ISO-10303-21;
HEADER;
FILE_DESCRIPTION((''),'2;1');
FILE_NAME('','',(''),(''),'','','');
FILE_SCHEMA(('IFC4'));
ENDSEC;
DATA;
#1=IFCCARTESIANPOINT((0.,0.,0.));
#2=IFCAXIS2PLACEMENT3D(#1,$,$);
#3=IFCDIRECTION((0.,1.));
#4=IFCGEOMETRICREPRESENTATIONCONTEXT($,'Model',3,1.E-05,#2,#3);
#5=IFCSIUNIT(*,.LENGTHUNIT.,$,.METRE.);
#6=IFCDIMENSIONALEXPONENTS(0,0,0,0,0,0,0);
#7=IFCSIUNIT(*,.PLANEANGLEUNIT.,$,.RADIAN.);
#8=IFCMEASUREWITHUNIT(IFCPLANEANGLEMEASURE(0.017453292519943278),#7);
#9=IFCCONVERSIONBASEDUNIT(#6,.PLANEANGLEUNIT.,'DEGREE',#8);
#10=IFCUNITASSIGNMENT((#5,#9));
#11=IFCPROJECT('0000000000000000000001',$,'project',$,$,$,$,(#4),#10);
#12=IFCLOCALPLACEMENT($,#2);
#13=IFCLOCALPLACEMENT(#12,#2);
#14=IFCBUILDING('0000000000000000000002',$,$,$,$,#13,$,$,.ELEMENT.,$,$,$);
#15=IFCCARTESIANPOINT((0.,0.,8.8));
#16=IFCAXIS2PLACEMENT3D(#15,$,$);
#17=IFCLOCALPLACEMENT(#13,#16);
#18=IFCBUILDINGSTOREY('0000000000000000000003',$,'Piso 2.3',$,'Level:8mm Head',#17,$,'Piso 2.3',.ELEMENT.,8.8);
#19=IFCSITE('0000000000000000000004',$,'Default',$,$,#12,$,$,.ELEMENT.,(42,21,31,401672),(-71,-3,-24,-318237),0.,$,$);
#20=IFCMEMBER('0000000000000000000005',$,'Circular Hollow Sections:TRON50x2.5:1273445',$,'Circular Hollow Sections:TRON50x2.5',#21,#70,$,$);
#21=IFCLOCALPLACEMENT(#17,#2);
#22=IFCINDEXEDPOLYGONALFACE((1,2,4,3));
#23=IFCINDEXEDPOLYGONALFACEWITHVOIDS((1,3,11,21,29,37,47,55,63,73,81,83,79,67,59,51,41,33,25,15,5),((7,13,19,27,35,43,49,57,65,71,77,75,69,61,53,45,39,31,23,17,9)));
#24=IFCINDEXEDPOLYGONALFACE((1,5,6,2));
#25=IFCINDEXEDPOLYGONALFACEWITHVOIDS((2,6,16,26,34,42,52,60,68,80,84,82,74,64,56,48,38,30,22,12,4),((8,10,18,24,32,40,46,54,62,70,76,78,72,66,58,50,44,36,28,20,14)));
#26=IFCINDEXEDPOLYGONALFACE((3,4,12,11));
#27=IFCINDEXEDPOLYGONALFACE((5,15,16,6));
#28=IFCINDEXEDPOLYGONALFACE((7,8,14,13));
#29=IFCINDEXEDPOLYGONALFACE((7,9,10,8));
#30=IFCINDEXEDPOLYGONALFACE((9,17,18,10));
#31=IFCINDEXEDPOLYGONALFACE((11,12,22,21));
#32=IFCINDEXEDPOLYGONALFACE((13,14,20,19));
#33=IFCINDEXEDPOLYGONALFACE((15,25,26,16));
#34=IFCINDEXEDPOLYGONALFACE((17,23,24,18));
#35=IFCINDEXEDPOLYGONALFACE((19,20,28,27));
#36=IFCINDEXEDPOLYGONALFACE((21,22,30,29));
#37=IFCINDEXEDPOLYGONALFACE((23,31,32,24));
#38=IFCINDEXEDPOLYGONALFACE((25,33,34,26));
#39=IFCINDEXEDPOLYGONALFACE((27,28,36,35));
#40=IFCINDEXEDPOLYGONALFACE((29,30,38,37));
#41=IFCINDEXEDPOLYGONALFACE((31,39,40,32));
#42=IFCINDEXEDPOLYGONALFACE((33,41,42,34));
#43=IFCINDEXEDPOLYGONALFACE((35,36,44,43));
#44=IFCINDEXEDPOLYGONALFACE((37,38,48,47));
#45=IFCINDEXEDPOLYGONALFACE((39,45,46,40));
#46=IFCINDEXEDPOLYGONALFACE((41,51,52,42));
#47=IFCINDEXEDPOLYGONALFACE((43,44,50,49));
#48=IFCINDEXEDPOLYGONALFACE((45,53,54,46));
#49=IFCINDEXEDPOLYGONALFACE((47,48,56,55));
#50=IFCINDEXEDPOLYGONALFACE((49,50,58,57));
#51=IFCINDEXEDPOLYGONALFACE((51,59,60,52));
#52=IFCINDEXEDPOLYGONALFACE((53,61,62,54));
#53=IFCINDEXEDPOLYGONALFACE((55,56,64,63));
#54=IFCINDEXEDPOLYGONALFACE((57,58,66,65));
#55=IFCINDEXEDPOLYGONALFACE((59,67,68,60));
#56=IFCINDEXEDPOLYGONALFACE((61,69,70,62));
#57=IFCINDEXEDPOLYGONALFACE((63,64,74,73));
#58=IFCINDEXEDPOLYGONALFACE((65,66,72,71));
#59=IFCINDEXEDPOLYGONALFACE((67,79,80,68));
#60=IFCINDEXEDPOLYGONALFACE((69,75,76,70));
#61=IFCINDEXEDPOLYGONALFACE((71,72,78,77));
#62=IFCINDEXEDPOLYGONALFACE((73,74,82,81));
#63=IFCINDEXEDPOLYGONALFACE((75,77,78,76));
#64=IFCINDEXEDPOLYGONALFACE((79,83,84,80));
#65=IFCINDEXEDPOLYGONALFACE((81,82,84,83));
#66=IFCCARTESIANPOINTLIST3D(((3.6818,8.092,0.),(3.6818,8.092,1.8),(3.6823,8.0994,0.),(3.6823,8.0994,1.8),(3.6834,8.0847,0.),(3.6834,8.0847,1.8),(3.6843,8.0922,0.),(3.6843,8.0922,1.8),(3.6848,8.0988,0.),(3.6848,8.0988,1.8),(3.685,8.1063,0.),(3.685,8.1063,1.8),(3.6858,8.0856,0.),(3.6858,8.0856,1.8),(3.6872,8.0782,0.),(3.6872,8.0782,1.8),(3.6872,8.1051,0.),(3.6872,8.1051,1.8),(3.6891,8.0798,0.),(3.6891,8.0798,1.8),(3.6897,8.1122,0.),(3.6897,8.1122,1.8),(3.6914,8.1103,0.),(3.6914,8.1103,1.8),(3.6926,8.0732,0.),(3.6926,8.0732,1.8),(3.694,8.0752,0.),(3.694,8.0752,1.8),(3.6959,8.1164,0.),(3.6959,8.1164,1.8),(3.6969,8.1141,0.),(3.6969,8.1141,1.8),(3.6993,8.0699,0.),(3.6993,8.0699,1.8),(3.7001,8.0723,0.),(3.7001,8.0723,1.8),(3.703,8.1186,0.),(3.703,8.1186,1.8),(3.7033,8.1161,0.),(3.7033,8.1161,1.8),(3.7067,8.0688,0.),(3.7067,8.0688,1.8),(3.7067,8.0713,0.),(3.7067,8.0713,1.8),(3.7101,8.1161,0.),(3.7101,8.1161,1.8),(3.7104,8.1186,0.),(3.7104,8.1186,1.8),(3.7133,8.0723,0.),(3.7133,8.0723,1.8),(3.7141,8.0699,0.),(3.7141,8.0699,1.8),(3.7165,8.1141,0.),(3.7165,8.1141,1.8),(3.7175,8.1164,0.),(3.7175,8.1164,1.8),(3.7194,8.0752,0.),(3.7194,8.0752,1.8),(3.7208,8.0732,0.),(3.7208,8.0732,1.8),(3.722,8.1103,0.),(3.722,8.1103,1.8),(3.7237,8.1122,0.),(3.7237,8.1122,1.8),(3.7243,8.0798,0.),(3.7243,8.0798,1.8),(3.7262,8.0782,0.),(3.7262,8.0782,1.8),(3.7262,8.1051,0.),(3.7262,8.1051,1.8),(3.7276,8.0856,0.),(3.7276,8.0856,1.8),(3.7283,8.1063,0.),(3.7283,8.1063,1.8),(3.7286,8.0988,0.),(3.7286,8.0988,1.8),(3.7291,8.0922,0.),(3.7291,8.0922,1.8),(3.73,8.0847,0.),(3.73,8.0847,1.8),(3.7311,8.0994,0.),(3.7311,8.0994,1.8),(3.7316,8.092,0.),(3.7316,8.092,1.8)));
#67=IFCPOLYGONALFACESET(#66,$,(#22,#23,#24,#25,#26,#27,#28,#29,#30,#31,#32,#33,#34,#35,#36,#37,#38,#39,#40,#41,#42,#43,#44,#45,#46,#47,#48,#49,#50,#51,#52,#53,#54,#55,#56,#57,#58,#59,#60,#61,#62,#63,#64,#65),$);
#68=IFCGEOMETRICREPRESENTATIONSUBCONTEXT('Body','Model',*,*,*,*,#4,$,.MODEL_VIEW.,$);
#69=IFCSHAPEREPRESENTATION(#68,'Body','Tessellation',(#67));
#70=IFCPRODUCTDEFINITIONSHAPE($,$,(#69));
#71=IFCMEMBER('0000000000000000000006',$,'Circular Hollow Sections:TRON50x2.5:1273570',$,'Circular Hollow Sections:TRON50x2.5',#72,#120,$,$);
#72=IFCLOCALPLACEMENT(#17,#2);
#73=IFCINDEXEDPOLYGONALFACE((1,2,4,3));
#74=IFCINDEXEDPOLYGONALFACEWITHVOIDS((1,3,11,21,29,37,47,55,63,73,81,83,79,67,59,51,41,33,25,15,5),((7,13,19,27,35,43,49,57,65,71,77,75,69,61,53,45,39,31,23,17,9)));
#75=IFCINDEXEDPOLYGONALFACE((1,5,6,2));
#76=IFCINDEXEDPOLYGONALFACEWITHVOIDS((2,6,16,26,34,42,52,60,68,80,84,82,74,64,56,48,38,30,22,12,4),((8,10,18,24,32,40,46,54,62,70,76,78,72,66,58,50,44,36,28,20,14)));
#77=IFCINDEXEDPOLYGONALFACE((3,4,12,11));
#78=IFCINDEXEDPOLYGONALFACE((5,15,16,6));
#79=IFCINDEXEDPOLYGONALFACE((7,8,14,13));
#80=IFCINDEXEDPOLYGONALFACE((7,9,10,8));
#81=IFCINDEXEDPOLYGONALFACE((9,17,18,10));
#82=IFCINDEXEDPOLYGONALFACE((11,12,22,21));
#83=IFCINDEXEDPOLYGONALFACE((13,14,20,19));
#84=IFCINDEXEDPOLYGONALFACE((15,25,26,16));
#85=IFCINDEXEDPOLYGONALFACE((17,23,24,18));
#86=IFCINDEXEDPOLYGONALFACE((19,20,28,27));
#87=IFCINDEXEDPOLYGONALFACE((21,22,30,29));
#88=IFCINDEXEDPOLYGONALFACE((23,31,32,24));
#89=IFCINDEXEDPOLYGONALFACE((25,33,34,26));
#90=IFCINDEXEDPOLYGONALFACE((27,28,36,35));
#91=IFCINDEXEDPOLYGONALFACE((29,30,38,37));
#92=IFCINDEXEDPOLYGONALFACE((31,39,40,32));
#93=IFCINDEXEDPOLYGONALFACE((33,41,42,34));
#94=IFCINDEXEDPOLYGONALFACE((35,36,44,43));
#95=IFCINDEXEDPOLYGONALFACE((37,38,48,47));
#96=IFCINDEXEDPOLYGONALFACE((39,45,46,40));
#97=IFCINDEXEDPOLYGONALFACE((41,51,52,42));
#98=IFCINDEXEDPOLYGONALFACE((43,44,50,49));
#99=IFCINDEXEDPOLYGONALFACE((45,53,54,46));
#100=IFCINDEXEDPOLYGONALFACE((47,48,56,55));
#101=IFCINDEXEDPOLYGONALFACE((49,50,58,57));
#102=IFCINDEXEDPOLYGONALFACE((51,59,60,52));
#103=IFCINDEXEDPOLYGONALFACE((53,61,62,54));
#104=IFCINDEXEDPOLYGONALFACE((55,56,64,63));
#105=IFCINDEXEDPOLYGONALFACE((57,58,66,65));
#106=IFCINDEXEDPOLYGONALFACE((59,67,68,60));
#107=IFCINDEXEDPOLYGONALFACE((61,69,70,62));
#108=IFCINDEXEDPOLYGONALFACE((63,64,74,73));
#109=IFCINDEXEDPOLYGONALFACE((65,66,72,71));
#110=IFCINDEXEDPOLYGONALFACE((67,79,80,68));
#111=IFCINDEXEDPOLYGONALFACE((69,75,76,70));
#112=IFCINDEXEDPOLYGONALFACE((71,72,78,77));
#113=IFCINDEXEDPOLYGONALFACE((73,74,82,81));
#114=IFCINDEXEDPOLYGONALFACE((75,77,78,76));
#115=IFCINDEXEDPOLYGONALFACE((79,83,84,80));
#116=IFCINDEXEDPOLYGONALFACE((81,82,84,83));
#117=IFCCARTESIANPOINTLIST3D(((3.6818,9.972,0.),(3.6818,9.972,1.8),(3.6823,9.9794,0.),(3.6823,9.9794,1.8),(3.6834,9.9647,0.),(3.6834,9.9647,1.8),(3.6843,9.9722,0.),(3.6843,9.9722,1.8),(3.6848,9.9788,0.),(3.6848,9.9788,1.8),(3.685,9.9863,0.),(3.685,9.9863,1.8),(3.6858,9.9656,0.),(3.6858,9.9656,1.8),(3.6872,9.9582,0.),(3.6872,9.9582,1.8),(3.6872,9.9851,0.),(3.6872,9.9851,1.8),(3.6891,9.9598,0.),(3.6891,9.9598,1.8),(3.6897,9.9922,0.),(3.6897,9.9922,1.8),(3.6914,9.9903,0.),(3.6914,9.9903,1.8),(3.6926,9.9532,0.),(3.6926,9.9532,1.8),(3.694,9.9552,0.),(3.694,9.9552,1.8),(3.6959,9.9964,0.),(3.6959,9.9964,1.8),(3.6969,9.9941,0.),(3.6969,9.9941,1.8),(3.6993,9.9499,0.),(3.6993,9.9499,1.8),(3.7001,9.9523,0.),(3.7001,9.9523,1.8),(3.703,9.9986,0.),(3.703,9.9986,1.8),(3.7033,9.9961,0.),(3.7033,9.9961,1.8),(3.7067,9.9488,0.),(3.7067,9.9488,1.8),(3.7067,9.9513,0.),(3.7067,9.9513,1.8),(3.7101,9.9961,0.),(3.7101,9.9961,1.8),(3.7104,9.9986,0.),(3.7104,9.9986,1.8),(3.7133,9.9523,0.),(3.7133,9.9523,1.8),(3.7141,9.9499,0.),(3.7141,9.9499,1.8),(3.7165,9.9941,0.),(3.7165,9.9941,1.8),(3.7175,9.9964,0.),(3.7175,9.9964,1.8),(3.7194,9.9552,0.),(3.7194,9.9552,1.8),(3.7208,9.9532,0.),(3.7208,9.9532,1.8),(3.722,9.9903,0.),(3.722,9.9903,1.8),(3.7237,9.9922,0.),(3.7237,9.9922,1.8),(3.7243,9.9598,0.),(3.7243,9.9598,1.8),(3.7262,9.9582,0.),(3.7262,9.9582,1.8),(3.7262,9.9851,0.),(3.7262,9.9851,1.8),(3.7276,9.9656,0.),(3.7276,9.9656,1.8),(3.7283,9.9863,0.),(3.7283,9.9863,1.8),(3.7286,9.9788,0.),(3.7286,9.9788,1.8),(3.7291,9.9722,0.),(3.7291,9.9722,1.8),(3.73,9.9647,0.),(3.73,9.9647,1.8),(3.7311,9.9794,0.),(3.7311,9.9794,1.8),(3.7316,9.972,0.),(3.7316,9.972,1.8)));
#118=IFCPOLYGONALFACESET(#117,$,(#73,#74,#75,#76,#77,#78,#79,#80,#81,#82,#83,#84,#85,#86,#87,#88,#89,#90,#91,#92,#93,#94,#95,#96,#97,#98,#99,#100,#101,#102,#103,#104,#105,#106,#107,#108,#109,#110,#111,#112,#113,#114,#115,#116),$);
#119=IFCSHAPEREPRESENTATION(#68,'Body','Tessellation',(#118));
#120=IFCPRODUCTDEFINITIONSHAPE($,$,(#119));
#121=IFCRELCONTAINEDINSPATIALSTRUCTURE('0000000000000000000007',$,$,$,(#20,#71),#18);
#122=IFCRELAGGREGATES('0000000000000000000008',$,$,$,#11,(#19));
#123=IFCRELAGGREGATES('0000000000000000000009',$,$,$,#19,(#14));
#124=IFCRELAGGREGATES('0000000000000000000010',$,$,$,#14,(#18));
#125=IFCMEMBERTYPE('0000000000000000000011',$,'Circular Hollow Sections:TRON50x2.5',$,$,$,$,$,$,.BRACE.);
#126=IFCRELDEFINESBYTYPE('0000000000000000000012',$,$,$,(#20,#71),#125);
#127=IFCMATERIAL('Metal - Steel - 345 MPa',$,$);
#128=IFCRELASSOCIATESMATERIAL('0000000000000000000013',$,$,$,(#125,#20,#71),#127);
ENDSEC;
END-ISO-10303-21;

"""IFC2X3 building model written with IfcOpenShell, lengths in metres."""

from ifc_helpers import new_model, entity, si_unit, converted_unit, direction, frame, frame_2d, origin, place, context, subcontext, project, spatial, hollow_circle, extrude, source, transform, mapped, material, type_object, type_shapes, element, save


model = new_model("IFC2X3")

# Units and contexts
model_context = context("Model", 3, precision=1e-05, world=origin(), true_north=direction((0.0, 1.0)))
body_context = subcontext(model_context, "Body", "Model", "MODEL_VIEW")
ifc_project = project(units=[si_unit("LENGTHUNIT", "METRE"), converted_unit("PLANEANGLEUNIT", "DEGREE", entity("IfcPlaneAngleMeasure", 0.017453292519943278), si_unit("PLANEANGLEUNIT", "RADIAN"), dimensions=[0, 0, 0, 0, 0, 0, 0])], contexts=[model_context])

# Site, building, storey
site_placement = place(None, origin())
site = spatial("IfcSite", under=ifc_project, at=site_placement, Name="Default", CompositionType="ELEMENT", RefLatitude=(42, 21, 31, 401672), RefLongitude=(-71, -3, -24, -318237), RefElevation=0.0)
building_placement = place(site_placement, origin())
building = spatial("IfcBuilding", under=site, at=building_placement, CompositionType="ELEMENT")
storey_placement = place(building_placement, frame((0.0, 0.0, 8.8)))
storey = spatial("IfcBuildingStorey", under=building, at=storey_placement, Name="Piso 2.3", ObjectType="Level:8mm Head", LongName="Piso 2.3", CompositionType="ELEMENT", Elevation=8.8)

# Shared definitions
ifc_material = material(Name="Metal - Steel - 345 MPa")

# Members
member_type_1 = type_object("IfcMemberType", Name="Circular Hollow Sections:TRON50x2.5", PredefinedType="BRACE", material=ifc_material)
shared_shape_1 = source(origin(), body_context, "Body", "SweptSolid", [
    extrude(hollow_circle(Radius=0.025, WallThickness=0.0025, at=frame_2d((0.0, 0.0), x_axis=(1.0, 0.0))), frame((-0.9, 0.0, 0.0), z_axis=(1.0, 0.0, 0.0), x_axis=(0.0, 0.0, -1.0)), (0.0, 0.0, 1.0), 1.8),
])
type_shapes(member_type_1, [shared_shape_1])
for number, where, z_axis, x_axis, name in (
    (1, (3.7067, 8.0938, 0.9), (0.0, 1.0, 0.0), (0.0, 0.0, 1.0), "Circular Hollow Sections:TRON50x2.5:1273445"),
    (2, (3.7067, 9.9738, 0.9), (0.0, 1.0, 0.0), (0.0, 0.0, 1.0), "Circular Hollow Sections:TRON50x2.5:1273570"),
):
    element("IfcMember", number, at=place(storey_placement, frame(where, z_axis=z_axis, x_axis=x_axis)), inside=storey, type_object=member_type_1, material=ifc_material, Name=name, ObjectType="Circular Hollow Sections:TRON50x2.5", context=body_context, shape_type="MappedRepresentation", body=[
        mapped(shared_shape_1, transform((0.0, 0.0, 0.0), scale=1.0)),
    ])

save(model, "model.ifc")
